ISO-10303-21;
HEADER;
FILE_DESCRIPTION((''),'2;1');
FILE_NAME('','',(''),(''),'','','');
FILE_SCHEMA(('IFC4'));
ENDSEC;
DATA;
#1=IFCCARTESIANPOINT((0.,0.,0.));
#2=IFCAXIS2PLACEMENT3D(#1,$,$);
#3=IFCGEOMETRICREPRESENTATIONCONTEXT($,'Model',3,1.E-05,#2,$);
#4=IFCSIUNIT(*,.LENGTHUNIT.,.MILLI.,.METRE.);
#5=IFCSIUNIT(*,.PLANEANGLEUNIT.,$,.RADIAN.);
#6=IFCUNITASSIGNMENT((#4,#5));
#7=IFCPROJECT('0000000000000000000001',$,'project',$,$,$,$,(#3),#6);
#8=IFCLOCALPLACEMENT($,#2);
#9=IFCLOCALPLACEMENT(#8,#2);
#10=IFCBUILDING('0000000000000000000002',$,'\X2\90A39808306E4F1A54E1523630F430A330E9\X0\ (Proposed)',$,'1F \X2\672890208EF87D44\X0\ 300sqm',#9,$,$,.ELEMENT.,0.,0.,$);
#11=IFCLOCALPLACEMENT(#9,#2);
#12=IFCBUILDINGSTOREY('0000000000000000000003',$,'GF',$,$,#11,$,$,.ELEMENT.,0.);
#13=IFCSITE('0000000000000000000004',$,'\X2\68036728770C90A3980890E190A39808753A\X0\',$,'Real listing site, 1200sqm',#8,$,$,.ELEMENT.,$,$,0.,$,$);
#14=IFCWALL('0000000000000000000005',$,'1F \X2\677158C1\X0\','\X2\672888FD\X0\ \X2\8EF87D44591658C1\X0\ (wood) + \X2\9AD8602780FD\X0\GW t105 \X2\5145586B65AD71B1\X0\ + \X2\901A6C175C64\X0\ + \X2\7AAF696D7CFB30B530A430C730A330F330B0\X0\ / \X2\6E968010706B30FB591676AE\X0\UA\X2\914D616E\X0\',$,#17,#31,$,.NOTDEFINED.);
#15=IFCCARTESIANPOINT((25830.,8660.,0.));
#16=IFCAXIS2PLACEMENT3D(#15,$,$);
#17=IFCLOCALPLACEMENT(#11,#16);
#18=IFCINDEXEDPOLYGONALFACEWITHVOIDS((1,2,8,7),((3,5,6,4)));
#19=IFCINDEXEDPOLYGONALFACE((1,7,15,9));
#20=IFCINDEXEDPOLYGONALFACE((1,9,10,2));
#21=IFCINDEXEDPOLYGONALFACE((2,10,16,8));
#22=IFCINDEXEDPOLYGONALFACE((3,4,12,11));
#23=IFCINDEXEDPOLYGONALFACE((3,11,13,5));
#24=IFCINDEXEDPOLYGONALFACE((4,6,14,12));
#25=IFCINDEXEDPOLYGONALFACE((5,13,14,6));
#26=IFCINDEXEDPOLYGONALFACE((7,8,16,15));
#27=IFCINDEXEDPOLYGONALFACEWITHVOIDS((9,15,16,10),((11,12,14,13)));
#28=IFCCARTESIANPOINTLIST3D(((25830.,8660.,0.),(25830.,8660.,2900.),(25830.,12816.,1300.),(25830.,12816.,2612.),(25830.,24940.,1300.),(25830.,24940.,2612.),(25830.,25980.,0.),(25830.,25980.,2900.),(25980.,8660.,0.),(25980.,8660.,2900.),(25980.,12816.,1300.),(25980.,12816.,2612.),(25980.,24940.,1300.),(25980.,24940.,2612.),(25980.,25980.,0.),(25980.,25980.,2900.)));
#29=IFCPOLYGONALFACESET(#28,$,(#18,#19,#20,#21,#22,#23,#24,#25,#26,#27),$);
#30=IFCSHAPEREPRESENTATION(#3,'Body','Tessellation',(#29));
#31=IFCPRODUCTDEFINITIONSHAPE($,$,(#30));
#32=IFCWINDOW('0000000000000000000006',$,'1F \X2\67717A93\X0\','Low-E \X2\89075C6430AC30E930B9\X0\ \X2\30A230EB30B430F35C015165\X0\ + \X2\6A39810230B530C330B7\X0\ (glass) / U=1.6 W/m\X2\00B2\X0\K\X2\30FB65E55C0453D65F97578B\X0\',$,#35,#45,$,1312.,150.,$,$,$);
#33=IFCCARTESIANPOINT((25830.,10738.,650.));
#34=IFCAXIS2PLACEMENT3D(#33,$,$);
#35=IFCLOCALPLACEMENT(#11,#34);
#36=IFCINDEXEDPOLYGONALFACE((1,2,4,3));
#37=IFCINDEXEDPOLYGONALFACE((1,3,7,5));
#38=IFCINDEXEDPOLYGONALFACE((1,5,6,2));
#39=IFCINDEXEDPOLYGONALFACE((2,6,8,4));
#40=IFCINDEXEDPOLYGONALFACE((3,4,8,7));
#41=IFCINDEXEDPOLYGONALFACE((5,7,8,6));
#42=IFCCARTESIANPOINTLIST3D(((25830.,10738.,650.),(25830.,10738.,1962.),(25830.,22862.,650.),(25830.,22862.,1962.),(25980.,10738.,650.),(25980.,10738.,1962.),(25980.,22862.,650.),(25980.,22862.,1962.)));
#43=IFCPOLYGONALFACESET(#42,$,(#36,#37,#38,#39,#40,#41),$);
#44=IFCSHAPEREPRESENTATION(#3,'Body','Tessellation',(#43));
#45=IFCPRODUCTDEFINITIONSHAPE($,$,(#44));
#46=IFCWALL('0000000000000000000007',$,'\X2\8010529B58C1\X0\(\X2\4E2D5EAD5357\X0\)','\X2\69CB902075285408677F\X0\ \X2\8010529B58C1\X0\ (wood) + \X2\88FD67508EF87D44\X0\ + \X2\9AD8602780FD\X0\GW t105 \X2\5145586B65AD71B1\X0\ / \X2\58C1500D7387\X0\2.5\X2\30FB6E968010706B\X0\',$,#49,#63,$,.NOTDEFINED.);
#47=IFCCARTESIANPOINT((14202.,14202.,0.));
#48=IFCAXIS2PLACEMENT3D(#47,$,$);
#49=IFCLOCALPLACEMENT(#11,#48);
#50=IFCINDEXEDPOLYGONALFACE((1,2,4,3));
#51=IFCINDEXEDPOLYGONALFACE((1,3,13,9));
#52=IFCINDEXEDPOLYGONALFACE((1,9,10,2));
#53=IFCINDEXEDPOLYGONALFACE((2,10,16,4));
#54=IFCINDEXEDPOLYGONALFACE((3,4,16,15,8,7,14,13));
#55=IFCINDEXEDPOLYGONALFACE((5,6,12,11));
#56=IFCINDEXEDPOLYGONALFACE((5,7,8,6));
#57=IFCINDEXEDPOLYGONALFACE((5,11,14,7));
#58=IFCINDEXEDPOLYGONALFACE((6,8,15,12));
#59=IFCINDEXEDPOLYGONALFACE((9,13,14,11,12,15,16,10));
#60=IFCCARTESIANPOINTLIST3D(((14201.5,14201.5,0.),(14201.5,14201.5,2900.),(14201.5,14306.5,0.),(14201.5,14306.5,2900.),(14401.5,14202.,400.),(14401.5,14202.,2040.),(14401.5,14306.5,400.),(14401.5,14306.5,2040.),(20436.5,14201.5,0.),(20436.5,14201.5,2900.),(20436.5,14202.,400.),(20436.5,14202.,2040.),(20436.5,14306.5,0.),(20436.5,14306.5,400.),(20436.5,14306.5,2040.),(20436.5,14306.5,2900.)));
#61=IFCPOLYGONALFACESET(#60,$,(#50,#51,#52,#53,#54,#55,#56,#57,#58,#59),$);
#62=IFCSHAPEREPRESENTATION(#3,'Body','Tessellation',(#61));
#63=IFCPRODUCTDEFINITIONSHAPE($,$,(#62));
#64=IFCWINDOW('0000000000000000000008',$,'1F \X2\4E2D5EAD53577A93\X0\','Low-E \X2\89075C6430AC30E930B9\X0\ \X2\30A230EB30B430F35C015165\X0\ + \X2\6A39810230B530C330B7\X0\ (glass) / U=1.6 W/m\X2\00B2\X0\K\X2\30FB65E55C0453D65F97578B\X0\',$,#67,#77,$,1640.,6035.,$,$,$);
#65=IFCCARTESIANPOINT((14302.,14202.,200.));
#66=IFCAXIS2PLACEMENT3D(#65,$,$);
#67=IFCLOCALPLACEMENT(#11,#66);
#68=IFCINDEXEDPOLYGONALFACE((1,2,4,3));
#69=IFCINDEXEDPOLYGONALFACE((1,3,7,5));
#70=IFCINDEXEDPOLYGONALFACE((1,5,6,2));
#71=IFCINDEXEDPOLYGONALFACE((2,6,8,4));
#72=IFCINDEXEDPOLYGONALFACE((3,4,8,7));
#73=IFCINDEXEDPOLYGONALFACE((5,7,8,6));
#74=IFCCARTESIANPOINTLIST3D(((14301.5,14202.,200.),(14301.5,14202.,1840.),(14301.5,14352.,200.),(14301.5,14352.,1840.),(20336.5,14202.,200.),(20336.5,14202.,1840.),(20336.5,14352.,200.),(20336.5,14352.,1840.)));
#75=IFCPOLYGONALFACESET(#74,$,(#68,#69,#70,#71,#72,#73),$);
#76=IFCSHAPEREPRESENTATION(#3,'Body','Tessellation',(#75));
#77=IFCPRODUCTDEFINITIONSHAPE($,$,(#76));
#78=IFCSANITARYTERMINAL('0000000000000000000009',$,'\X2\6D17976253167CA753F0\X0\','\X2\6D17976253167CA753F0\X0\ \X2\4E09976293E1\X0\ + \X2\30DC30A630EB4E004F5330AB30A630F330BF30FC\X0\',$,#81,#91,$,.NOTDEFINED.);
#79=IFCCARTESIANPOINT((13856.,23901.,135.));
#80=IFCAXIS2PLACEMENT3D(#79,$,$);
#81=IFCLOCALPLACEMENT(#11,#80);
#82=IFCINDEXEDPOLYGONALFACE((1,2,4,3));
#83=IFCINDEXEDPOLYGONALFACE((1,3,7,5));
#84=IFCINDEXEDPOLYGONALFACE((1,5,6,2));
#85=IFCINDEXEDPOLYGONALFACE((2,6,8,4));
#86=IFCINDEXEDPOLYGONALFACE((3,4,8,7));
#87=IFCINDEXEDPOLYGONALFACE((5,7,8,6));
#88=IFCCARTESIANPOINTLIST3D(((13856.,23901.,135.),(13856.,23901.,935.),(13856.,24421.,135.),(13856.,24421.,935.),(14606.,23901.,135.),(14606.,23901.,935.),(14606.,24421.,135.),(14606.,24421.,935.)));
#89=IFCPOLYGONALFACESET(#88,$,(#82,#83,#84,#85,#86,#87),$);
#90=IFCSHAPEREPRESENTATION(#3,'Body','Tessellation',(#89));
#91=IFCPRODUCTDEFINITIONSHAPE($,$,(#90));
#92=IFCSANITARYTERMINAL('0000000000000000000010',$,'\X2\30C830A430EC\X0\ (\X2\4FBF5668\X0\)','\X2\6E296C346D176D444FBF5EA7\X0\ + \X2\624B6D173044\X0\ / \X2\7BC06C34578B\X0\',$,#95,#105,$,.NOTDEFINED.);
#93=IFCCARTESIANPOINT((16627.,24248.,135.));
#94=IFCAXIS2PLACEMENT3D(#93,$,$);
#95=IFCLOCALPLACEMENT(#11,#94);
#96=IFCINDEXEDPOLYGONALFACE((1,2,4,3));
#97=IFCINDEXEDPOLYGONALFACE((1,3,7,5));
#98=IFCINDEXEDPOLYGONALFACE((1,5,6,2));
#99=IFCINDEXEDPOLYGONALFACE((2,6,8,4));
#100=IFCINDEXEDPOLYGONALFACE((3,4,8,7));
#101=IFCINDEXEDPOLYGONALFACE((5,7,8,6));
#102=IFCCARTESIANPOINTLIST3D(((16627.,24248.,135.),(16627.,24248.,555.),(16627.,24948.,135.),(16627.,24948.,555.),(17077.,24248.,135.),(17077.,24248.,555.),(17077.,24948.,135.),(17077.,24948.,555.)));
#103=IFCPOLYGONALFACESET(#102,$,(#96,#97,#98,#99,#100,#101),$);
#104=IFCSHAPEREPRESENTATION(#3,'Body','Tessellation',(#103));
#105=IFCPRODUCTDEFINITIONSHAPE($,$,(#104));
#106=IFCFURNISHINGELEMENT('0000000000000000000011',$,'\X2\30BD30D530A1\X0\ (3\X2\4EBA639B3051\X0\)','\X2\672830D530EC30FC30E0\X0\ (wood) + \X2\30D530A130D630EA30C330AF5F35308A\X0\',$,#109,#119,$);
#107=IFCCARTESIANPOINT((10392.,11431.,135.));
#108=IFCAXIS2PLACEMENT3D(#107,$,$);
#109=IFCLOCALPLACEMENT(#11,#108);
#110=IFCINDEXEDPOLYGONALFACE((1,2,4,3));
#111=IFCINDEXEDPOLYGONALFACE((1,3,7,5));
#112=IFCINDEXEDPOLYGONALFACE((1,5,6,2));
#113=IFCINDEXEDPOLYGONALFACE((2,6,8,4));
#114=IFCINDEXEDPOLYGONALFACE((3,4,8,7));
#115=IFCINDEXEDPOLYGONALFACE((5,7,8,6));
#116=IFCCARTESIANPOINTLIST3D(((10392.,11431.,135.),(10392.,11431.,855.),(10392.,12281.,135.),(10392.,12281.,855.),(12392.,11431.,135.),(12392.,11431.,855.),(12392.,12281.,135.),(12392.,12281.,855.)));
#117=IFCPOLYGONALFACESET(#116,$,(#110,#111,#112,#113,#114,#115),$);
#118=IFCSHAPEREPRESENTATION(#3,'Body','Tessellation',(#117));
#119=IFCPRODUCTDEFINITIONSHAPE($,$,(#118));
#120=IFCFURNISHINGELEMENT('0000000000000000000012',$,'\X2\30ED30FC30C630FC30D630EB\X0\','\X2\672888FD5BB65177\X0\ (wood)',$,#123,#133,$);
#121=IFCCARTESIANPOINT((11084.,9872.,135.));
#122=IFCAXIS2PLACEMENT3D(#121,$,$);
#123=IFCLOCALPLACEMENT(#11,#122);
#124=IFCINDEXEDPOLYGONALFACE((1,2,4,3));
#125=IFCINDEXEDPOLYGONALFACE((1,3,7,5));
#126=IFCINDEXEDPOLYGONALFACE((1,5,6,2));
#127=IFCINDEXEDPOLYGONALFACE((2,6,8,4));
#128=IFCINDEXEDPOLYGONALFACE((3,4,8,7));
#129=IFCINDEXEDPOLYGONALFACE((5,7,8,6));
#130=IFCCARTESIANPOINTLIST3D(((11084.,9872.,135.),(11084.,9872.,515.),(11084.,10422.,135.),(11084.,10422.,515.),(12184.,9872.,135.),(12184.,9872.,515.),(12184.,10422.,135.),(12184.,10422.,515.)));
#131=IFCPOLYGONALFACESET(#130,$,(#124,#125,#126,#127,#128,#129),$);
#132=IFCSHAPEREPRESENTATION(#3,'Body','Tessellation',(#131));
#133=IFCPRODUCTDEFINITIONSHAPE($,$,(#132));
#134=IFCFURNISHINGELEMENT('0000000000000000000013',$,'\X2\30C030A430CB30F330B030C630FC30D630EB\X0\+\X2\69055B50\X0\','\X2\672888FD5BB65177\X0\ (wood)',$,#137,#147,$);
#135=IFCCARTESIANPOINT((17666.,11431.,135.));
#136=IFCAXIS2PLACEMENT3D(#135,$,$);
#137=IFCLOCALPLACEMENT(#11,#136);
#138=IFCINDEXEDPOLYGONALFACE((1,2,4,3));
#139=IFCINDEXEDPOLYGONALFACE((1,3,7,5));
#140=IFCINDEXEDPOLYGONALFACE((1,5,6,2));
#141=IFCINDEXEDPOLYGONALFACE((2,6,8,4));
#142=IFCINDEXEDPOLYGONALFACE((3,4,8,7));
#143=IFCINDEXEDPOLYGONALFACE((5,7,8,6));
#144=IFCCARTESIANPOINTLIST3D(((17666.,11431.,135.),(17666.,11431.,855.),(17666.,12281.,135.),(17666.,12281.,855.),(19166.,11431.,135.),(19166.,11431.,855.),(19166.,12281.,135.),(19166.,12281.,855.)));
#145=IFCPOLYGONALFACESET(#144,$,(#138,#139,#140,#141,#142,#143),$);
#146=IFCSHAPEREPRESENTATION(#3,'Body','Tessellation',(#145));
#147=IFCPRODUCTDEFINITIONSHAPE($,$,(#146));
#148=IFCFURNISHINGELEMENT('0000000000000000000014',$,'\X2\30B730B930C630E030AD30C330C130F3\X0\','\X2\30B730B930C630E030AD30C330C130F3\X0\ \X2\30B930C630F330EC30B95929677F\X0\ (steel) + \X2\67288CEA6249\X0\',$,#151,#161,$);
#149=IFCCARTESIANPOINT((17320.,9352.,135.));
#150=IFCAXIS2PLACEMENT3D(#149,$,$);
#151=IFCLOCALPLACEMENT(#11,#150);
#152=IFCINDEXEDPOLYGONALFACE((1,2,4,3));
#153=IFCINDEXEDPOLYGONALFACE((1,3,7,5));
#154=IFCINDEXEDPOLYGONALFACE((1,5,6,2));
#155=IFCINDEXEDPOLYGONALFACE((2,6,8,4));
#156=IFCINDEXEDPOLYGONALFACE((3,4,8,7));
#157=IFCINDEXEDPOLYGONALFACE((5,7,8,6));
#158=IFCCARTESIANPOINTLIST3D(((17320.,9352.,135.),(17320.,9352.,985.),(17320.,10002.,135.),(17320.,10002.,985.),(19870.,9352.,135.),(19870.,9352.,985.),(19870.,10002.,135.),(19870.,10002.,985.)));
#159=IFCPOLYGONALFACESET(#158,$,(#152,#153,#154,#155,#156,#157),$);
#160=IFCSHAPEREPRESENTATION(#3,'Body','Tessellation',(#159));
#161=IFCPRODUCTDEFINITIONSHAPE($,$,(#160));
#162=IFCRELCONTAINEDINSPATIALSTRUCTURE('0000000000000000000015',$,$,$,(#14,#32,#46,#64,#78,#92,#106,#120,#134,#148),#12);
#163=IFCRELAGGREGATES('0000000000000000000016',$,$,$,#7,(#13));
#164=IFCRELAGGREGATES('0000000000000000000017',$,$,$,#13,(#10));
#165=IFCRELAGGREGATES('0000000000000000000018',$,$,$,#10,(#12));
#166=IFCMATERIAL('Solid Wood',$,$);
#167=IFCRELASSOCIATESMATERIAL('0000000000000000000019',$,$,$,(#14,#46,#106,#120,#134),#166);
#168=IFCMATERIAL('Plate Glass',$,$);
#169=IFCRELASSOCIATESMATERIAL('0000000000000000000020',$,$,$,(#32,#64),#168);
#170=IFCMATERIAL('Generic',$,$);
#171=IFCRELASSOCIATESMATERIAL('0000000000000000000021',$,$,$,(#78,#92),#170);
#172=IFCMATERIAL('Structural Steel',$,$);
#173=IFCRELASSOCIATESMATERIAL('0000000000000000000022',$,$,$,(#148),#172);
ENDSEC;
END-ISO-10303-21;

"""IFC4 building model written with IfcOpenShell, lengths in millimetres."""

from ifc_helpers import new_model, si_unit, frame, frame_2d, origin, place, context, project, spatial, rectangle, extrude, material, element, fill, save


model = new_model("IFC4")

# Units and contexts
model_context = context("Model", 3, precision=1e-05, world=origin())
ifc_project = project(units=[si_unit("LENGTHUNIT", "METRE", prefix="MILLI"), si_unit("PLANEANGLEUNIT", "RADIAN")], contexts=[model_context])

# Site, building, storey
site_placement = place(None, origin())
site = spatial("IfcSite", under=ifc_project, at=site_placement, Name="栃木県那須郡那須町", ObjectType="Real listing site, 1200sqm", CompositionType="ELEMENT", RefElevation=0.0)
building_placement = place(site_placement, origin())
building = spatial("IfcBuilding", under=site, at=building_placement, Name="那須の会員制ヴィラ (Proposed)", ObjectType="1F 木造軸組 300sqm", CompositionType="ELEMENT", ElevationOfRefHeight=0.0, ElevationOfTerrain=0.0)
storey_placement = place(building_placement, origin())
storey = spatial("IfcBuildingStorey", under=building, at=storey_placement, Name="GF", CompositionType="ELEMENT", Elevation=0.0)

# Shared definitions
ifc_material_1 = material(Name="Solid Wood")

# Walls, openings, windows
wall_1_placement = place(storey_placement, frame((25830.0, 8660.0, 0.0)))
wall_1 = element("IfcWall", 1, at=wall_1_placement, inside=storey, material=ifc_material_1, Name="1F 東壁", Description="木製 軸組外壁 (wood) + 高性能GW t105 充填断熱 + 通気層 + 窯業系サイディング / 準耐火・外皮UA配慮", PredefinedType="NOTDEFINED", context=model_context, shape_type="SweptSolid", body=[
    extrude(rectangle(XDim=150.0, YDim=17320.0, at=frame_2d((75.0, 8660.0))), frame((25830.0, 8660.0, 0.0)), (0.0, 0.0, 1.0), 2900.0),
])
opening_1_placement = place(storey_placement, frame((25830.0, 10738.0, 650.0)))
opening_1 = element("IfcOpeningElement", 2, at=opening_1_placement, cuts=wall_1, PredefinedType="NOTDEFINED", context=model_context, shape_type="SweptSolid", body=[
    extrude(rectangle(XDim=150.0, YDim=12124.0, at=frame_2d((75.0, 6062.0))), frame((25830.0, 10738.0, 650.0)), (0.0, 0.0, 1.0), 1312.0),
])
ifc_material_2 = material(Name="Plate Glass")
window_1_placement = place(storey_placement, frame((25830.0, 10738.0, 650.0)))
window_1 = element("IfcWindow", 3, at=window_1_placement, inside=storey, material=ifc_material_2, Name="1F 東窓", Description="Low-E 複層ガラス アルゴン封入 + 樹脂サッシ (glass) / U=1.6 W/m²K・日射取得型", OverallHeight=1312.0, OverallWidth=150.0, context=model_context, shape_type="SweptSolid", body=[
    extrude(rectangle(XDim=150.0, YDim=12124.0, at=frame_2d((75.0, 6062.0))), frame((25830.0, 10738.0, 650.0)), (0.0, 0.0, 1.0), 1312.0),
])
fill(opening_1, window_1)
wall_2_placement = place(storey_placement, frame((14202.0, 14202.0, 0.0)))
wall_2 = element("IfcWall", 4, at=wall_2_placement, inside=storey, material=ifc_material_1, Name="耐力壁(中庭南)", Description="構造用合板 耐力壁 (wood) + 製材軸組 + 高性能GW t105 充填断熱 / 壁倍率2.5・準耐火", PredefinedType="NOTDEFINED", context=model_context, shape_type="SweptSolid", body=[
    extrude(rectangle(XDim=6235.0, YDim=105.0, at=frame_2d((3117.0, 52.0))), frame((14202.0, 14202.0, 0.0)), (0.0, 0.0, 1.0), 2900.0),
])
opening_2_placement = place(storey_placement, frame((14302.0, 14202.0, 200.0)))
opening_2 = element("IfcOpeningElement", 5, at=opening_2_placement, cuts=wall_2, PredefinedType="NOTDEFINED", context=model_context, shape_type="SweptSolid", body=[
    extrude(rectangle(XDim=6035.0, YDim=150.0, at=frame_2d((3017.0, 75.0))), frame((14302.0, 14202.0, 200.0)), (0.0, 0.0, 1.0), 1640.0),
])
window_2_placement = place(storey_placement, frame((14302.0, 14202.0, 200.0)))
window_2 = element("IfcWindow", 6, at=window_2_placement, inside=storey, material=ifc_material_2, Name="1F 中庭南窓", Description="Low-E 複層ガラス アルゴン封入 + 樹脂サッシ (glass) / U=1.6 W/m²K・日射取得型", OverallHeight=1640.0, OverallWidth=6035.0, context=model_context, shape_type="SweptSolid", body=[
    extrude(rectangle(XDim=6035.0, YDim=150.0, at=frame_2d((3017.0, 75.0))), frame((14302.0, 14202.0, 200.0)), (0.0, 0.0, 1.0), 1640.0),
])
fill(opening_2, window_2)

# Shared definitions
ifc_material_3 = material(Name="Structural Steel")

# Shared definitions
ifc_material_4 = material(Name="Generic")

# Sanitary terminals
sanitary_terminal_1_placement = place(storey_placement, frame((13856.0, 23901.0, 135.0)))
element("IfcSanitaryTerminal", 7, at=sanitary_terminal_1_placement, inside=storey, material=ifc_material_4, Name="洗面化粧台", Description="洗面化粧台 三面鏡 + ボウル一体カウンター", PredefinedType="NOTDEFINED", context=model_context, shape_type="SweptSolid", body=[
    extrude(rectangle(XDim=750.0, YDim=520.0, at=frame_2d((375.0, 260.0))), frame((13856.0, 23901.0, 135.0)), (0.0, 0.0, 1.0), 800.0),
])
sanitary_terminal_2_placement = place(storey_placement, frame((16627.0, 24248.0, 135.0)))
element("IfcSanitaryTerminal", 8, at=sanitary_terminal_2_placement, inside=storey, material=ifc_material_4, Name="トイレ (便器)", Description="温水洗浄便座 + 手洗い / 節水型", PredefinedType="NOTDEFINED", context=model_context, shape_type="SweptSolid", body=[
    extrude(rectangle(XDim=450.0, YDim=700.0, at=frame_2d((225.0, 350.0))), frame((16627.0, 24248.0, 135.0)), (0.0, 0.0, 1.0), 420.0),
])

# Furnishing elements
furnishing_1_placement = place(storey_placement, frame((10392.0, 11431.0, 135.0)))
element("IfcFurnishingElement", 9, at=furnishing_1_placement, inside=storey, material=ifc_material_1, Name="ソファ (3人掛け)", Description="木フレーム (wood) + ファブリック張り", context=model_context, shape_type="SweptSolid", body=[
    extrude(rectangle(XDim=2000.0, YDim=850.0, at=frame_2d((1000.0, 425.0))), frame((10392.0, 11431.0, 135.0)), (0.0, 0.0, 1.0), 720.0),
])
furnishing_2_placement = place(storey_placement, frame((11084.0, 9872.0, 135.0)))
element("IfcFurnishingElement", 10, at=furnishing_2_placement, inside=storey, material=ifc_material_1, Name="ローテーブル", Description="木製家具 (wood)", context=model_context, shape_type="SweptSolid", body=[
    extrude(rectangle(XDim=1100.0, YDim=550.0, at=frame_2d((550.0, 275.0))), frame((11084.0, 9872.0, 135.0)), (0.0, 0.0, 1.0), 380.0),
])
furnishing_3_placement = place(storey_placement, frame((17666.0, 11431.0, 135.0)))
element("IfcFurnishingElement", 11, at=furnishing_3_placement, inside=storey, material=ifc_material_1, Name="ダイニングテーブル+椅子", Description="木製家具 (wood)", context=model_context, shape_type="SweptSolid", body=[
    extrude(rectangle(XDim=1500.0, YDim=850.0, at=frame_2d((750.0, 425.0))), frame((17666.0, 11431.0, 135.0)), (0.0, 0.0, 1.0), 720.0),
])
furnishing_4_placement = place(storey_placement, frame((17320.0, 9352.0, 135.0)))
element("IfcFurnishingElement", 12, at=furnishing_4_placement, inside=storey, material=ifc_material_3, Name="システムキッチン", Description="システムキッチン ステンレス天板 (steel) + 木質扉", context=model_context, shape_type="SweptSolid", body=[
    extrude(rectangle(XDim=2550.0, YDim=650.0, at=frame_2d((1275.0, 325.0))), frame((17320.0, 9352.0, 135.0)), (0.0, 0.0, 1.0), 850.0),
])

save(model, "model.ifc")
